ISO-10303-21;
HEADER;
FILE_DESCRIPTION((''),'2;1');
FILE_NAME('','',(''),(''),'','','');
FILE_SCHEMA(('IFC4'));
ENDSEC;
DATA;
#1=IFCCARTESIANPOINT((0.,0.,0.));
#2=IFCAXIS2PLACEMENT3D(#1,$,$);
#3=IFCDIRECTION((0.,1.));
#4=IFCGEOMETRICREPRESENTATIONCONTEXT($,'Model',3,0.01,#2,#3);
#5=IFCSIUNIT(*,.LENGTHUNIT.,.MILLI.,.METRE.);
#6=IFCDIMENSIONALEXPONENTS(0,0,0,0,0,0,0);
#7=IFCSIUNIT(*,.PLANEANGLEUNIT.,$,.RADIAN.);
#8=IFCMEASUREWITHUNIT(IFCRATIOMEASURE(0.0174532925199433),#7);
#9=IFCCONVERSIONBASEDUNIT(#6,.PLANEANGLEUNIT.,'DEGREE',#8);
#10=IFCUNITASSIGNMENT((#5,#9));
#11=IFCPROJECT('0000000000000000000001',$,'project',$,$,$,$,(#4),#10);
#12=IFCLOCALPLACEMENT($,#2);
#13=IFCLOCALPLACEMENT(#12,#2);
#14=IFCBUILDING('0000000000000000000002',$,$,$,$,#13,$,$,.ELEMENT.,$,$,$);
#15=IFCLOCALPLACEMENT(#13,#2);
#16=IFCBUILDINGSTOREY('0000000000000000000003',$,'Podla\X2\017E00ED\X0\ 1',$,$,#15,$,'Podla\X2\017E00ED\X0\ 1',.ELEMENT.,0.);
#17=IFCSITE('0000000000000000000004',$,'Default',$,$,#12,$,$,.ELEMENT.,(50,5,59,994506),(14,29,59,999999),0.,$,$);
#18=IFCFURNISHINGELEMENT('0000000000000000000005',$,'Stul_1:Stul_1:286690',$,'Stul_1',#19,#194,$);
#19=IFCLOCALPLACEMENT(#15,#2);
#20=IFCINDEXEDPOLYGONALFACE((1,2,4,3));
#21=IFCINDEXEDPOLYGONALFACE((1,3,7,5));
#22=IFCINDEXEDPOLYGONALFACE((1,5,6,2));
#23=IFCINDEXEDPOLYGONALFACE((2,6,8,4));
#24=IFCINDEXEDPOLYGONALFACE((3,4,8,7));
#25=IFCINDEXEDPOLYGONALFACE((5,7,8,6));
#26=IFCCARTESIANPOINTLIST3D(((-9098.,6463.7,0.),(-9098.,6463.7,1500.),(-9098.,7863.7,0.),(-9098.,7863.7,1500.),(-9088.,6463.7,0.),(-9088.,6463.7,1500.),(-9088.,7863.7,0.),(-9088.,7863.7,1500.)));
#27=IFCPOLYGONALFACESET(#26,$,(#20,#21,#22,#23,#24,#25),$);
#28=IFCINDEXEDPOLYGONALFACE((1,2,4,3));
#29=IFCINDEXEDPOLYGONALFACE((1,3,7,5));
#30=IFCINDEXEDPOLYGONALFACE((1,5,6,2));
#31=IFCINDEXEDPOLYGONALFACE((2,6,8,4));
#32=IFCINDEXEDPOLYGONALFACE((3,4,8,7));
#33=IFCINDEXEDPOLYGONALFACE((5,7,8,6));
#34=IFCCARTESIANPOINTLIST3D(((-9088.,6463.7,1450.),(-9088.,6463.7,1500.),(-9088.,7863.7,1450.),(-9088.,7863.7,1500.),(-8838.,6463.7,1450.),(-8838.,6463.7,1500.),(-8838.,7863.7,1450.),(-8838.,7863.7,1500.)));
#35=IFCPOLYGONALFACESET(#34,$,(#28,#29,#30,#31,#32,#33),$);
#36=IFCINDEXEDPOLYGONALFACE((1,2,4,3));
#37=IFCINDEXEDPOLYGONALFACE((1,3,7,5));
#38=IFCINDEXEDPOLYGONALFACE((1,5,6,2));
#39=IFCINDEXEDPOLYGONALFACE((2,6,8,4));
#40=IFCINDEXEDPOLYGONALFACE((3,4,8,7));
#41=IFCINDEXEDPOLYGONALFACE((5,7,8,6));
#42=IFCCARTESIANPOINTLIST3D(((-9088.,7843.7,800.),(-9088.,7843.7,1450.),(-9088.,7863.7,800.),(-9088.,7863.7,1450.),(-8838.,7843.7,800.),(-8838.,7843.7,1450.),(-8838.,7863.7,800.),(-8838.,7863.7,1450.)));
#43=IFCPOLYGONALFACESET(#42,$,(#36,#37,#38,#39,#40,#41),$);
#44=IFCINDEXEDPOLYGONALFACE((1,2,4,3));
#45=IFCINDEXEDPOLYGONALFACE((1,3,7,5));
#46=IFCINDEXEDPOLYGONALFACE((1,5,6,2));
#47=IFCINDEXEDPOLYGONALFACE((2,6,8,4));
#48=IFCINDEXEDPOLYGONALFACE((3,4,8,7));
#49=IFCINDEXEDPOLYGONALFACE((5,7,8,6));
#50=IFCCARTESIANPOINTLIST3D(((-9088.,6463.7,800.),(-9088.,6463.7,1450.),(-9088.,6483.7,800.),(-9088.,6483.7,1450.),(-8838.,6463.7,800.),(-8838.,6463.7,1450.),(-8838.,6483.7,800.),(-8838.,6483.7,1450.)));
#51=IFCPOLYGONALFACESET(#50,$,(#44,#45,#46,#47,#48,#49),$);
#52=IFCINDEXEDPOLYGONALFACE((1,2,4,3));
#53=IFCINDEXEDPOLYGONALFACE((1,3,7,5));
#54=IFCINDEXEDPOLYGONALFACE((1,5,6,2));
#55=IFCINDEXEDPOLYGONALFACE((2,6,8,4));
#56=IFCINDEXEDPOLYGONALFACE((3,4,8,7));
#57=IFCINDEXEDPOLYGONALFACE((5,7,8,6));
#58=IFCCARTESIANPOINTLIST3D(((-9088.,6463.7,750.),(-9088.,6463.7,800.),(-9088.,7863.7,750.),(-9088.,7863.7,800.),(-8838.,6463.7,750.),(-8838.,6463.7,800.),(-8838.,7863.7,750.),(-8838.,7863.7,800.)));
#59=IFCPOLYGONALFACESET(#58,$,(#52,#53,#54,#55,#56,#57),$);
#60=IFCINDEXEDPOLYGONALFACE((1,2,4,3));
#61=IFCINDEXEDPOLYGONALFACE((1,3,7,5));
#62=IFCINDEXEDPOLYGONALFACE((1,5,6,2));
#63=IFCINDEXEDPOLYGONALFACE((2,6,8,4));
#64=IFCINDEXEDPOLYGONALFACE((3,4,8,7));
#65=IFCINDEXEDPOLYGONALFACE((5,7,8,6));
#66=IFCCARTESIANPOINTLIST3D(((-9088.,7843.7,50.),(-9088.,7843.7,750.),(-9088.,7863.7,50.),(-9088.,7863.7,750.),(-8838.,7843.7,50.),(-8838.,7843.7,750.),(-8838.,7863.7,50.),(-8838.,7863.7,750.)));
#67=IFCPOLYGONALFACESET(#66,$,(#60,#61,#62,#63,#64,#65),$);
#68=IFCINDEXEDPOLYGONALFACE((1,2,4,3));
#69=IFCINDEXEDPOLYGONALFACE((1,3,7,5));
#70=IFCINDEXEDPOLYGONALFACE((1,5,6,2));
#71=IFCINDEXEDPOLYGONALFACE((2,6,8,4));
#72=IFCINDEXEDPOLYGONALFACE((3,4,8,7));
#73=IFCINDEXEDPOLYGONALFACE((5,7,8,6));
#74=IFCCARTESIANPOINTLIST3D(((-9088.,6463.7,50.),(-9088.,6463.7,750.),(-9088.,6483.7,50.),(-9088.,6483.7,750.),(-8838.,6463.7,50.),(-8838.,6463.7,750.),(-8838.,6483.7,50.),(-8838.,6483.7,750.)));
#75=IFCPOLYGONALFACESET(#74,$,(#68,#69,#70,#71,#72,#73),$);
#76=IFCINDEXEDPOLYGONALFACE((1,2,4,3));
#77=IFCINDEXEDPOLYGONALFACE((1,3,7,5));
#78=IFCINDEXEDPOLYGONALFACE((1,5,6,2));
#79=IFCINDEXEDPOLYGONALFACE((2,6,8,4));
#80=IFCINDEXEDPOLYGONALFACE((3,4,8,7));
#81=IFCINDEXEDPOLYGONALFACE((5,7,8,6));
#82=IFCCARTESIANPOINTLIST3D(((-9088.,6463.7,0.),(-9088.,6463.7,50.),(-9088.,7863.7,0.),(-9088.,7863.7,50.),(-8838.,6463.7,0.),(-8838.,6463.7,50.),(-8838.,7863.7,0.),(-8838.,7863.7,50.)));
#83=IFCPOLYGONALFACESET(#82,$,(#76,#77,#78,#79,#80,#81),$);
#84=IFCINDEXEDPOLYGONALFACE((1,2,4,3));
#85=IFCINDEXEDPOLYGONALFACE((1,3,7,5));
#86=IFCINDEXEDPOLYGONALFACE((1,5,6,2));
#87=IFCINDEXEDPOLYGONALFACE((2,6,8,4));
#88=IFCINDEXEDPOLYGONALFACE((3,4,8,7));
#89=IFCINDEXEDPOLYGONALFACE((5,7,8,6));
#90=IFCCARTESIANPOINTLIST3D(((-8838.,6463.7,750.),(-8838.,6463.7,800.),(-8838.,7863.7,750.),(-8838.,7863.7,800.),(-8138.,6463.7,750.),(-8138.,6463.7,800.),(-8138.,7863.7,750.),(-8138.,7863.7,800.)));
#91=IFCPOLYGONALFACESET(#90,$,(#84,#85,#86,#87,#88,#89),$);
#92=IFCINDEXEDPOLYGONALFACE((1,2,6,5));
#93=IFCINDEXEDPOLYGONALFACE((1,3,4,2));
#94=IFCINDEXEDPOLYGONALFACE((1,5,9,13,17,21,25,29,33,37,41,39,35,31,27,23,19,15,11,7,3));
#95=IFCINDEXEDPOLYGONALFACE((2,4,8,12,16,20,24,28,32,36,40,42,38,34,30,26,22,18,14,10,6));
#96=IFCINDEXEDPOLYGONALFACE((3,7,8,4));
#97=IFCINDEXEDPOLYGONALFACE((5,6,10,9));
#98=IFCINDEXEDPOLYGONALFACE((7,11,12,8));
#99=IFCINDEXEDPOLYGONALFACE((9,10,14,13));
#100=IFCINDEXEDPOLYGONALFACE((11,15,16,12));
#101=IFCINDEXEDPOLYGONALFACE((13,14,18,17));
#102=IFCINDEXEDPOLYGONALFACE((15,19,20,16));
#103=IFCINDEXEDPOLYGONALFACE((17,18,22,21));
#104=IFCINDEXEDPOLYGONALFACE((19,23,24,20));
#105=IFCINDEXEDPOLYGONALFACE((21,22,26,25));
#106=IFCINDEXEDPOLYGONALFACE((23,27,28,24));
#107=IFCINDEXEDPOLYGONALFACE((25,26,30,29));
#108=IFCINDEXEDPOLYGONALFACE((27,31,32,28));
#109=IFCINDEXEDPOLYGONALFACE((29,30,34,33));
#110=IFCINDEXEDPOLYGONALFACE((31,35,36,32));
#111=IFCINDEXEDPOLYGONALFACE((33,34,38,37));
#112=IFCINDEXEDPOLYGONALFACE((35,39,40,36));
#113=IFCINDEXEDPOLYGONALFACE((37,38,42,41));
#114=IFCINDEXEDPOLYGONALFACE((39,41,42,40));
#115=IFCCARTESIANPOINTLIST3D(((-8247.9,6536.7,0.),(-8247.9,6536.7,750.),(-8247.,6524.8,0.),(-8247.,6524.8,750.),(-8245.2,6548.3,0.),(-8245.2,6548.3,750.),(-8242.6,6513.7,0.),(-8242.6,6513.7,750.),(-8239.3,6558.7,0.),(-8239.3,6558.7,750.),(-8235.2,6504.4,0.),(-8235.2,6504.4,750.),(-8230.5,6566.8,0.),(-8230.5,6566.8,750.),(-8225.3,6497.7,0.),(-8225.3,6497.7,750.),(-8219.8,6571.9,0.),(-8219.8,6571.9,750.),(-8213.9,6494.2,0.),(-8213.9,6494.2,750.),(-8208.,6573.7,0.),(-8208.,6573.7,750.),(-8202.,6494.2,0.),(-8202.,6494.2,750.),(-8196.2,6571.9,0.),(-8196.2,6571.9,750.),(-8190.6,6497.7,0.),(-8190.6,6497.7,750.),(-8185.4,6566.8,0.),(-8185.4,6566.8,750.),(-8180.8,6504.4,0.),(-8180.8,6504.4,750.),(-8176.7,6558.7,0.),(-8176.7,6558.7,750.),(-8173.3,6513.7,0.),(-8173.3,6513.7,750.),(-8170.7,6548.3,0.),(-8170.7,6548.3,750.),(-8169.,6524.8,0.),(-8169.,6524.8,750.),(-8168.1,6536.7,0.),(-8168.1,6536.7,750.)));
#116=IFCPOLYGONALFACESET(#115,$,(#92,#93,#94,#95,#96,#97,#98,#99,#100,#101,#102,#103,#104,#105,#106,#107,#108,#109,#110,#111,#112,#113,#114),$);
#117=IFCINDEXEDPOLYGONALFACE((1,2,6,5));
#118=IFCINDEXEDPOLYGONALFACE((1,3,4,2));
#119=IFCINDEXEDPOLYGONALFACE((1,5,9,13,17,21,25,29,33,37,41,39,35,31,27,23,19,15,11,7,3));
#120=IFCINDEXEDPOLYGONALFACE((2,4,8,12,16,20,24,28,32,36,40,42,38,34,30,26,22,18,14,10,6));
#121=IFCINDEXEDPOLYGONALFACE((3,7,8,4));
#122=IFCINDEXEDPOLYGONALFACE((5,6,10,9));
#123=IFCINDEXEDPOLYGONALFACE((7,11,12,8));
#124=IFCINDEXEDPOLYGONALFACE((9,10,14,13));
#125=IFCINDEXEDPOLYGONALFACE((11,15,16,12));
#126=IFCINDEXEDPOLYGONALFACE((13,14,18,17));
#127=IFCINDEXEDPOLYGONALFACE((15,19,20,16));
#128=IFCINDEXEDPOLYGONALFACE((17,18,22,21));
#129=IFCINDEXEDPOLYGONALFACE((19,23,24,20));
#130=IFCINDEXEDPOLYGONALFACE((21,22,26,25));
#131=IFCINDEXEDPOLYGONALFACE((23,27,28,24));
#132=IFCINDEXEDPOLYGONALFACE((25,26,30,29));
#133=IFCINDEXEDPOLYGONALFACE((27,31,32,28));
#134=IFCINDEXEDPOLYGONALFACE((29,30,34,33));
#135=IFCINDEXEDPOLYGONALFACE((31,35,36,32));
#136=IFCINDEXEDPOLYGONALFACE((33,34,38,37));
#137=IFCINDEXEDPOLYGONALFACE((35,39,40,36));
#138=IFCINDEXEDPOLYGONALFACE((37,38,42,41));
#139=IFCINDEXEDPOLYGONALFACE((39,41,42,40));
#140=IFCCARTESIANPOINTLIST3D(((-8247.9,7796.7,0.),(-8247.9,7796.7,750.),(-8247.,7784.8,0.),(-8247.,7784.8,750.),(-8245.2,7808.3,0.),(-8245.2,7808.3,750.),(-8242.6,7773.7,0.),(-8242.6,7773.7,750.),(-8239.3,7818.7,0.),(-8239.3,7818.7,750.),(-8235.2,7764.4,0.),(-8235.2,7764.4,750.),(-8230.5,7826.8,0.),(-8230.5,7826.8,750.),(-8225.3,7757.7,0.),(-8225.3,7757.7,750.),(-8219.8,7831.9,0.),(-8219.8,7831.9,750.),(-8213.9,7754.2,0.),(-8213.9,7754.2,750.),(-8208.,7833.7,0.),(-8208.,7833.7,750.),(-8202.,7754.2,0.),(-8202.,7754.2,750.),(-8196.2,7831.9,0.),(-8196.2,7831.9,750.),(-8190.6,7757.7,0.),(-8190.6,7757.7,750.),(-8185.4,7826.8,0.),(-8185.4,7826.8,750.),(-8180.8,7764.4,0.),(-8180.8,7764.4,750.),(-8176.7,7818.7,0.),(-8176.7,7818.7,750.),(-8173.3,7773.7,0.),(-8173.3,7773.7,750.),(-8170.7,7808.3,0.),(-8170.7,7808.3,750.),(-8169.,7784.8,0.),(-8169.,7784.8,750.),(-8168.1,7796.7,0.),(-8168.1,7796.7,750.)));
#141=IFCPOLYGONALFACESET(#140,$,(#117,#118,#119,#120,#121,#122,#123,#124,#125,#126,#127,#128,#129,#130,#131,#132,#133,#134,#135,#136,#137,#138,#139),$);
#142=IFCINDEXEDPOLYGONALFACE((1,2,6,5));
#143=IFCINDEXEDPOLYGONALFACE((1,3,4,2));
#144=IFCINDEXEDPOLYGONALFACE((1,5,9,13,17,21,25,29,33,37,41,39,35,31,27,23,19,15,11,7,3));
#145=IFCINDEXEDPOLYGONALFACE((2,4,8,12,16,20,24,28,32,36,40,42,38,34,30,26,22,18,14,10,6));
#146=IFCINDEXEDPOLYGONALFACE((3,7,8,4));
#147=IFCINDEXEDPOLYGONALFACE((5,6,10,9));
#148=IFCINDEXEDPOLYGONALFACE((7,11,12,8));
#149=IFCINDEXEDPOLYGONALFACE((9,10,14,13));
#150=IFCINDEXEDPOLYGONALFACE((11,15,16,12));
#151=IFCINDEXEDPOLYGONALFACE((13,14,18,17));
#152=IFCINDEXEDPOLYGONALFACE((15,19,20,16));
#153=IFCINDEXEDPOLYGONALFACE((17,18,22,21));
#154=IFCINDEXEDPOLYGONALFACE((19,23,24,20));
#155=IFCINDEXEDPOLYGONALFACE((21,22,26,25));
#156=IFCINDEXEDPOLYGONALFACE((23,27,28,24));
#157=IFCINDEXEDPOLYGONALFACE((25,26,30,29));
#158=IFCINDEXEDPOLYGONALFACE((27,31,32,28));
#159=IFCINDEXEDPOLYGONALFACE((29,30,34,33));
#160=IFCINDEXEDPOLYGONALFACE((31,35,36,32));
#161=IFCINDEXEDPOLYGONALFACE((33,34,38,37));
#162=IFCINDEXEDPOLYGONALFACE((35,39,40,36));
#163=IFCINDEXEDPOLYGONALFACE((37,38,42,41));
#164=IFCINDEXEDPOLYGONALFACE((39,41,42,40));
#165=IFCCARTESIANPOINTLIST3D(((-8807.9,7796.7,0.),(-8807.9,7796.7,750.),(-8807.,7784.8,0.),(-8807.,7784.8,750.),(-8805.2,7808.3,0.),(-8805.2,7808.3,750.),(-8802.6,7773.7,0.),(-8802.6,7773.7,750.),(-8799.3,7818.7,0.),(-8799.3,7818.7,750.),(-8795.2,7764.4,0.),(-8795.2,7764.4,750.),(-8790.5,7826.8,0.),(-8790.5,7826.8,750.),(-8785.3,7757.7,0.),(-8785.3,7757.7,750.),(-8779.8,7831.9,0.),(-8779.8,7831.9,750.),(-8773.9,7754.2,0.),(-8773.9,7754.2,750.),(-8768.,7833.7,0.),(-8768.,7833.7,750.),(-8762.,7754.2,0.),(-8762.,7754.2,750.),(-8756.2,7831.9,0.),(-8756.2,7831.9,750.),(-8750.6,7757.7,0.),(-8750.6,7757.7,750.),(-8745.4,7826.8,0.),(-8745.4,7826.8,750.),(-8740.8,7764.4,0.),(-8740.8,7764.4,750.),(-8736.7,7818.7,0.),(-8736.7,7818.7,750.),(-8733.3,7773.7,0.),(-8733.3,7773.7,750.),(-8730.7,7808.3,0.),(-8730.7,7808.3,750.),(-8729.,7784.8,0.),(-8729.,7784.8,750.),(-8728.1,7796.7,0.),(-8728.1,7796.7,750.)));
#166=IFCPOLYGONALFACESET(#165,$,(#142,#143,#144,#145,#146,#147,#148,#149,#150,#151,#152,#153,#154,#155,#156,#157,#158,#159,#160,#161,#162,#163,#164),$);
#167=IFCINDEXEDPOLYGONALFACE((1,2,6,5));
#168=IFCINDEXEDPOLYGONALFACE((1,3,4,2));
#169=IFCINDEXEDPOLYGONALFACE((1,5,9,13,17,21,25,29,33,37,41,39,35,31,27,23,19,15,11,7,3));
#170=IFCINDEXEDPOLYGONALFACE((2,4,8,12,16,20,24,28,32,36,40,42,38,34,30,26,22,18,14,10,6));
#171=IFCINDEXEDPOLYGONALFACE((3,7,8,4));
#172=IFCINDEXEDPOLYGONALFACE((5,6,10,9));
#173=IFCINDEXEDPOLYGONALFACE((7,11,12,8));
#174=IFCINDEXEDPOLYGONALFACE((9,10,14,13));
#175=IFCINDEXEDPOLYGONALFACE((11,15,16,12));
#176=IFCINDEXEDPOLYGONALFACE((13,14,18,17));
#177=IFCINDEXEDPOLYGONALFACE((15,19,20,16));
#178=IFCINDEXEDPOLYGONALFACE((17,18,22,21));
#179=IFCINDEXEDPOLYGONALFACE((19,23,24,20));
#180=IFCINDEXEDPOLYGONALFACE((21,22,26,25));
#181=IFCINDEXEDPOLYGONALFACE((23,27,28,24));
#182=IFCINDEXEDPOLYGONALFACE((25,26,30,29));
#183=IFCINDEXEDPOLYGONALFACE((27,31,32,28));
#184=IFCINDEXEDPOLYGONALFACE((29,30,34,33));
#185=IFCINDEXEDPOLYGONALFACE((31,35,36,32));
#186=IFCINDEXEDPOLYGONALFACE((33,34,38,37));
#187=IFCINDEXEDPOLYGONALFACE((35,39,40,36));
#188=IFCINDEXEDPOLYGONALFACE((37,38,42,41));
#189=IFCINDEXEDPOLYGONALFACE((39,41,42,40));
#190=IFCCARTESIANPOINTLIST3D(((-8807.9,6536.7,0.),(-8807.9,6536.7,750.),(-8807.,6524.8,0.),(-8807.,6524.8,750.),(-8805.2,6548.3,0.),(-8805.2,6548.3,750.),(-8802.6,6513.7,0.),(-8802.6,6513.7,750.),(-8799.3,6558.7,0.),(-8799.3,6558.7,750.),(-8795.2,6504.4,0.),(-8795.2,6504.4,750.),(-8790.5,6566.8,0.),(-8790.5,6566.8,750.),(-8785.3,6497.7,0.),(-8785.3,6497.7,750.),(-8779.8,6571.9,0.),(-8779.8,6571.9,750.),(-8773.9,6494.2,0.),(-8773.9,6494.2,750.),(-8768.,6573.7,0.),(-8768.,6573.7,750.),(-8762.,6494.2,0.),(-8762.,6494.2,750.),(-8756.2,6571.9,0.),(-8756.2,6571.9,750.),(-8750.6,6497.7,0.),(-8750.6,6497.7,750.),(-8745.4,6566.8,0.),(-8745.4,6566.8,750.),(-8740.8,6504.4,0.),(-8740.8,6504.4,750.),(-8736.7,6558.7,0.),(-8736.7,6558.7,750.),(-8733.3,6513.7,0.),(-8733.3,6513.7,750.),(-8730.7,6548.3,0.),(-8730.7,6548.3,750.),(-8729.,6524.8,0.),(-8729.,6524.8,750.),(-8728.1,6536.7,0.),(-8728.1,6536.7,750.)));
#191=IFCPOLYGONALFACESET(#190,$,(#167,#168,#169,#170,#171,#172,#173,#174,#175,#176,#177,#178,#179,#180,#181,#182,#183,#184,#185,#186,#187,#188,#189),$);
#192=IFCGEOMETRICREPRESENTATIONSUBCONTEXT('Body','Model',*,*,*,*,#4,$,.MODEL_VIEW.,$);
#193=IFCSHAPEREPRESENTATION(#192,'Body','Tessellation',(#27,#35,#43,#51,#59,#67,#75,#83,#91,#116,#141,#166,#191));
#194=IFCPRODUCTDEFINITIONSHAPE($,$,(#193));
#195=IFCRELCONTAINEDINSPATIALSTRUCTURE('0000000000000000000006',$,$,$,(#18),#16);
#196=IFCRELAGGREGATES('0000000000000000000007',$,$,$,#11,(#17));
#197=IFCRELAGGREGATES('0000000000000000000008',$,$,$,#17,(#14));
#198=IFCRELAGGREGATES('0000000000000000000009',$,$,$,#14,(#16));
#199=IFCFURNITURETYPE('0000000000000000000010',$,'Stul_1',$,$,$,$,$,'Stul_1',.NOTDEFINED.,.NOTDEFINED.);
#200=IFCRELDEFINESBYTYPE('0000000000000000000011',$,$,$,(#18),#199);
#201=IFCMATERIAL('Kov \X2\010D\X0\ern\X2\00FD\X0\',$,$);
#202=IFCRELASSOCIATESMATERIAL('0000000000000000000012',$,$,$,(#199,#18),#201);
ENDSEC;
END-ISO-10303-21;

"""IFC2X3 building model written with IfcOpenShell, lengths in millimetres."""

from ifc_helpers import new_model, entity, si_unit, converted_unit, direction, frame, frame_2d, origin, origin_2d_with_axis, place, context, subcontext, project, spatial, rectangle, circle, extrude, source, transform, mapped, material, type_object, type_shapes, element, save


model = new_model("IFC2X3")

# Units and contexts
model_context = context("Model", 3, precision=0.01, world=origin(), true_north=direction((0.0, 1.0)))
body_context = subcontext(model_context, "Body", "Model", "MODEL_VIEW")
ifc_project = project(units=[si_unit("LENGTHUNIT", "METRE", prefix="MILLI"), converted_unit("PLANEANGLEUNIT", "DEGREE", entity("IfcRatioMeasure", 0.0174532925199433), si_unit("PLANEANGLEUNIT", "RADIAN"), dimensions=[0, 0, 0, 0, 0, 0, 0])], contexts=[model_context])

# Site, building, storey
site_placement = place(None, origin())
site = spatial("IfcSite", under=ifc_project, at=site_placement, Name="Default", CompositionType="ELEMENT", RefLatitude=(50, 5, 59, 994506), RefLongitude=(14, 29, 59, 999999), RefElevation=0.0)
building_placement = place(site_placement, origin())
building = spatial("IfcBuilding", under=site, at=building_placement, CompositionType="ELEMENT")
storey_placement = place(building_placement, origin())
storey = spatial("IfcBuildingStorey", under=building, at=storey_placement, Name="Podlaží 1", LongName="Podlaží 1", CompositionType="ELEMENT", Elevation=0.0)

# Furnishing element
ifc_material_1 = material(Name="Kov černý")
furniture_type = type_object("IfcFurnitureType", Name="Stul_1", ElementType="Stul_1", material=ifc_material_1)
shared_shape_1 = source(origin(), body_context, "Body", "SweptSolid", [
    extrude(rectangle(XDim=1400.0, YDim=10.0, at=origin_2d_with_axis()), frame((0.0, 605.0, 0.0), z_axis=(0.0, 0.0, 1.0), x_axis=(-1.0, 0.0, 0.0)), (0.0, 0.0, 1.0), 1500.0),
    extrude(rectangle(XDim=1400.0, YDim=250.0, at=frame_2d((0.0, 0.0), x_axis=(1.0, 0.0))), frame((0.0, 475.0, 1450.0), z_axis=(0.0, 0.0, 1.0), x_axis=(-1.0, 0.0, 0.0)), (0.0, 0.0, 1.0), 50.0),
    extrude(rectangle(XDim=20.0, YDim=250.0, at=origin_2d_with_axis()), frame((690.0, 475.0, 800.0), z_axis=(0.0, 0.0, 1.0), x_axis=(-1.0, 0.0, 0.0)), (0.0, 0.0, 1.0), 650.0),
    extrude(rectangle(XDim=20.0, YDim=250.0, at=frame_2d((0.0, 0.0), x_axis=(1.0, 0.0))), frame((-690.0, 475.0, 800.0), z_axis=(0.0, 0.0, 1.0), x_axis=(-1.0, 0.0, 0.0)), (0.0, 0.0, 1.0), 650.0),
    extrude(rectangle(XDim=1400.0, YDim=250.0, at=origin_2d_with_axis()), frame((0.0, 475.0, 750.0), z_axis=(0.0, 0.0, 1.0), x_axis=(-1.0, 0.0, 0.0)), (0.0, 0.0, 1.0), 50.0),
    extrude(rectangle(XDim=20.0, YDim=250.0, at=origin_2d_with_axis()), frame((690.0, 475.0, 50.0), z_axis=(0.0, 0.0, 1.0), x_axis=(-1.0, 0.0, 0.0)), (0.0, 0.0, 1.0), 700.0),
    extrude(rectangle(XDim=20.0, YDim=250.0, at=frame_2d((0.0, 0.0), x_axis=(1.0, 0.0))), frame((-690.0, 475.0, 50.0), z_axis=(0.0, 0.0, 1.0), x_axis=(-1.0, 0.0, 0.0)), (0.0, 0.0, 1.0), 700.0),
    extrude(rectangle(XDim=1400.0, YDim=250.0, at=origin_2d_with_axis()), frame((0.0, 475.0, 0.0), z_axis=(0.0, 0.0, 1.0), x_axis=(-1.0, 0.0, 0.0)), (0.0, 0.0, 1.0), 50.0),
    extrude(rectangle(XDim=1400.0, YDim=700.0, at=origin_2d_with_axis()), frame((0.0, 0.0, 750.0), z_axis=(0.0, 0.0, 1.0), x_axis=(-1.0, 0.0, 0.0)), (0.0, 0.0, 1.0), 50.0),
    extrude(circle(Radius=40.0, at=frame_2d((0.0, 0.0), x_axis=(1.0, 0.0))), frame((-630.0, -280.0, 0.0)), (0.0, 0.0, 1.0), 750.0),
    extrude(circle(Radius=40.0, at=frame_2d((0.0, 0.0), x_axis=(1.0, 0.0))), frame((630.0, -280.0, 0.0)), (0.0, 0.0, 1.0), 750.0),
    extrude(circle(Radius=40.0, at=frame_2d((0.0, 0.0), x_axis=(1.0, 0.0))), frame((630.0, 280.0, 0.0)), (0.0, 0.0, 1.0), 750.0),
    extrude(circle(Radius=40.0, at=frame_2d((0.0, 0.0), x_axis=(1.0, 0.0))), frame((-630.0, 280.0, 0.0)), (0.0, 0.0, 1.0), 750.0),
])
type_shapes(furniture_type, [shared_shape_1])
for number, where, z_axis, x_axis, name in (
    (1, (-8488.0, 7163.7, 0.0), (0.0, 0.0, 1.0), (0.0, 1.0, 0.0), "Stul_1:Stul_1:286690"),
):
    element("IfcFurnishingElement", number, at=place(storey_placement, frame(where, z_axis=z_axis, x_axis=x_axis)), inside=storey, type_object=furniture_type, material=ifc_material_1, Name=name, ObjectType="Stul_1", context=body_context, shape_type="MappedRepresentation", body=[
        mapped(shared_shape_1, transform((0.0, 0.0, 0.0), scale=1.0)),
    ])

save(model, "model.ifc")
